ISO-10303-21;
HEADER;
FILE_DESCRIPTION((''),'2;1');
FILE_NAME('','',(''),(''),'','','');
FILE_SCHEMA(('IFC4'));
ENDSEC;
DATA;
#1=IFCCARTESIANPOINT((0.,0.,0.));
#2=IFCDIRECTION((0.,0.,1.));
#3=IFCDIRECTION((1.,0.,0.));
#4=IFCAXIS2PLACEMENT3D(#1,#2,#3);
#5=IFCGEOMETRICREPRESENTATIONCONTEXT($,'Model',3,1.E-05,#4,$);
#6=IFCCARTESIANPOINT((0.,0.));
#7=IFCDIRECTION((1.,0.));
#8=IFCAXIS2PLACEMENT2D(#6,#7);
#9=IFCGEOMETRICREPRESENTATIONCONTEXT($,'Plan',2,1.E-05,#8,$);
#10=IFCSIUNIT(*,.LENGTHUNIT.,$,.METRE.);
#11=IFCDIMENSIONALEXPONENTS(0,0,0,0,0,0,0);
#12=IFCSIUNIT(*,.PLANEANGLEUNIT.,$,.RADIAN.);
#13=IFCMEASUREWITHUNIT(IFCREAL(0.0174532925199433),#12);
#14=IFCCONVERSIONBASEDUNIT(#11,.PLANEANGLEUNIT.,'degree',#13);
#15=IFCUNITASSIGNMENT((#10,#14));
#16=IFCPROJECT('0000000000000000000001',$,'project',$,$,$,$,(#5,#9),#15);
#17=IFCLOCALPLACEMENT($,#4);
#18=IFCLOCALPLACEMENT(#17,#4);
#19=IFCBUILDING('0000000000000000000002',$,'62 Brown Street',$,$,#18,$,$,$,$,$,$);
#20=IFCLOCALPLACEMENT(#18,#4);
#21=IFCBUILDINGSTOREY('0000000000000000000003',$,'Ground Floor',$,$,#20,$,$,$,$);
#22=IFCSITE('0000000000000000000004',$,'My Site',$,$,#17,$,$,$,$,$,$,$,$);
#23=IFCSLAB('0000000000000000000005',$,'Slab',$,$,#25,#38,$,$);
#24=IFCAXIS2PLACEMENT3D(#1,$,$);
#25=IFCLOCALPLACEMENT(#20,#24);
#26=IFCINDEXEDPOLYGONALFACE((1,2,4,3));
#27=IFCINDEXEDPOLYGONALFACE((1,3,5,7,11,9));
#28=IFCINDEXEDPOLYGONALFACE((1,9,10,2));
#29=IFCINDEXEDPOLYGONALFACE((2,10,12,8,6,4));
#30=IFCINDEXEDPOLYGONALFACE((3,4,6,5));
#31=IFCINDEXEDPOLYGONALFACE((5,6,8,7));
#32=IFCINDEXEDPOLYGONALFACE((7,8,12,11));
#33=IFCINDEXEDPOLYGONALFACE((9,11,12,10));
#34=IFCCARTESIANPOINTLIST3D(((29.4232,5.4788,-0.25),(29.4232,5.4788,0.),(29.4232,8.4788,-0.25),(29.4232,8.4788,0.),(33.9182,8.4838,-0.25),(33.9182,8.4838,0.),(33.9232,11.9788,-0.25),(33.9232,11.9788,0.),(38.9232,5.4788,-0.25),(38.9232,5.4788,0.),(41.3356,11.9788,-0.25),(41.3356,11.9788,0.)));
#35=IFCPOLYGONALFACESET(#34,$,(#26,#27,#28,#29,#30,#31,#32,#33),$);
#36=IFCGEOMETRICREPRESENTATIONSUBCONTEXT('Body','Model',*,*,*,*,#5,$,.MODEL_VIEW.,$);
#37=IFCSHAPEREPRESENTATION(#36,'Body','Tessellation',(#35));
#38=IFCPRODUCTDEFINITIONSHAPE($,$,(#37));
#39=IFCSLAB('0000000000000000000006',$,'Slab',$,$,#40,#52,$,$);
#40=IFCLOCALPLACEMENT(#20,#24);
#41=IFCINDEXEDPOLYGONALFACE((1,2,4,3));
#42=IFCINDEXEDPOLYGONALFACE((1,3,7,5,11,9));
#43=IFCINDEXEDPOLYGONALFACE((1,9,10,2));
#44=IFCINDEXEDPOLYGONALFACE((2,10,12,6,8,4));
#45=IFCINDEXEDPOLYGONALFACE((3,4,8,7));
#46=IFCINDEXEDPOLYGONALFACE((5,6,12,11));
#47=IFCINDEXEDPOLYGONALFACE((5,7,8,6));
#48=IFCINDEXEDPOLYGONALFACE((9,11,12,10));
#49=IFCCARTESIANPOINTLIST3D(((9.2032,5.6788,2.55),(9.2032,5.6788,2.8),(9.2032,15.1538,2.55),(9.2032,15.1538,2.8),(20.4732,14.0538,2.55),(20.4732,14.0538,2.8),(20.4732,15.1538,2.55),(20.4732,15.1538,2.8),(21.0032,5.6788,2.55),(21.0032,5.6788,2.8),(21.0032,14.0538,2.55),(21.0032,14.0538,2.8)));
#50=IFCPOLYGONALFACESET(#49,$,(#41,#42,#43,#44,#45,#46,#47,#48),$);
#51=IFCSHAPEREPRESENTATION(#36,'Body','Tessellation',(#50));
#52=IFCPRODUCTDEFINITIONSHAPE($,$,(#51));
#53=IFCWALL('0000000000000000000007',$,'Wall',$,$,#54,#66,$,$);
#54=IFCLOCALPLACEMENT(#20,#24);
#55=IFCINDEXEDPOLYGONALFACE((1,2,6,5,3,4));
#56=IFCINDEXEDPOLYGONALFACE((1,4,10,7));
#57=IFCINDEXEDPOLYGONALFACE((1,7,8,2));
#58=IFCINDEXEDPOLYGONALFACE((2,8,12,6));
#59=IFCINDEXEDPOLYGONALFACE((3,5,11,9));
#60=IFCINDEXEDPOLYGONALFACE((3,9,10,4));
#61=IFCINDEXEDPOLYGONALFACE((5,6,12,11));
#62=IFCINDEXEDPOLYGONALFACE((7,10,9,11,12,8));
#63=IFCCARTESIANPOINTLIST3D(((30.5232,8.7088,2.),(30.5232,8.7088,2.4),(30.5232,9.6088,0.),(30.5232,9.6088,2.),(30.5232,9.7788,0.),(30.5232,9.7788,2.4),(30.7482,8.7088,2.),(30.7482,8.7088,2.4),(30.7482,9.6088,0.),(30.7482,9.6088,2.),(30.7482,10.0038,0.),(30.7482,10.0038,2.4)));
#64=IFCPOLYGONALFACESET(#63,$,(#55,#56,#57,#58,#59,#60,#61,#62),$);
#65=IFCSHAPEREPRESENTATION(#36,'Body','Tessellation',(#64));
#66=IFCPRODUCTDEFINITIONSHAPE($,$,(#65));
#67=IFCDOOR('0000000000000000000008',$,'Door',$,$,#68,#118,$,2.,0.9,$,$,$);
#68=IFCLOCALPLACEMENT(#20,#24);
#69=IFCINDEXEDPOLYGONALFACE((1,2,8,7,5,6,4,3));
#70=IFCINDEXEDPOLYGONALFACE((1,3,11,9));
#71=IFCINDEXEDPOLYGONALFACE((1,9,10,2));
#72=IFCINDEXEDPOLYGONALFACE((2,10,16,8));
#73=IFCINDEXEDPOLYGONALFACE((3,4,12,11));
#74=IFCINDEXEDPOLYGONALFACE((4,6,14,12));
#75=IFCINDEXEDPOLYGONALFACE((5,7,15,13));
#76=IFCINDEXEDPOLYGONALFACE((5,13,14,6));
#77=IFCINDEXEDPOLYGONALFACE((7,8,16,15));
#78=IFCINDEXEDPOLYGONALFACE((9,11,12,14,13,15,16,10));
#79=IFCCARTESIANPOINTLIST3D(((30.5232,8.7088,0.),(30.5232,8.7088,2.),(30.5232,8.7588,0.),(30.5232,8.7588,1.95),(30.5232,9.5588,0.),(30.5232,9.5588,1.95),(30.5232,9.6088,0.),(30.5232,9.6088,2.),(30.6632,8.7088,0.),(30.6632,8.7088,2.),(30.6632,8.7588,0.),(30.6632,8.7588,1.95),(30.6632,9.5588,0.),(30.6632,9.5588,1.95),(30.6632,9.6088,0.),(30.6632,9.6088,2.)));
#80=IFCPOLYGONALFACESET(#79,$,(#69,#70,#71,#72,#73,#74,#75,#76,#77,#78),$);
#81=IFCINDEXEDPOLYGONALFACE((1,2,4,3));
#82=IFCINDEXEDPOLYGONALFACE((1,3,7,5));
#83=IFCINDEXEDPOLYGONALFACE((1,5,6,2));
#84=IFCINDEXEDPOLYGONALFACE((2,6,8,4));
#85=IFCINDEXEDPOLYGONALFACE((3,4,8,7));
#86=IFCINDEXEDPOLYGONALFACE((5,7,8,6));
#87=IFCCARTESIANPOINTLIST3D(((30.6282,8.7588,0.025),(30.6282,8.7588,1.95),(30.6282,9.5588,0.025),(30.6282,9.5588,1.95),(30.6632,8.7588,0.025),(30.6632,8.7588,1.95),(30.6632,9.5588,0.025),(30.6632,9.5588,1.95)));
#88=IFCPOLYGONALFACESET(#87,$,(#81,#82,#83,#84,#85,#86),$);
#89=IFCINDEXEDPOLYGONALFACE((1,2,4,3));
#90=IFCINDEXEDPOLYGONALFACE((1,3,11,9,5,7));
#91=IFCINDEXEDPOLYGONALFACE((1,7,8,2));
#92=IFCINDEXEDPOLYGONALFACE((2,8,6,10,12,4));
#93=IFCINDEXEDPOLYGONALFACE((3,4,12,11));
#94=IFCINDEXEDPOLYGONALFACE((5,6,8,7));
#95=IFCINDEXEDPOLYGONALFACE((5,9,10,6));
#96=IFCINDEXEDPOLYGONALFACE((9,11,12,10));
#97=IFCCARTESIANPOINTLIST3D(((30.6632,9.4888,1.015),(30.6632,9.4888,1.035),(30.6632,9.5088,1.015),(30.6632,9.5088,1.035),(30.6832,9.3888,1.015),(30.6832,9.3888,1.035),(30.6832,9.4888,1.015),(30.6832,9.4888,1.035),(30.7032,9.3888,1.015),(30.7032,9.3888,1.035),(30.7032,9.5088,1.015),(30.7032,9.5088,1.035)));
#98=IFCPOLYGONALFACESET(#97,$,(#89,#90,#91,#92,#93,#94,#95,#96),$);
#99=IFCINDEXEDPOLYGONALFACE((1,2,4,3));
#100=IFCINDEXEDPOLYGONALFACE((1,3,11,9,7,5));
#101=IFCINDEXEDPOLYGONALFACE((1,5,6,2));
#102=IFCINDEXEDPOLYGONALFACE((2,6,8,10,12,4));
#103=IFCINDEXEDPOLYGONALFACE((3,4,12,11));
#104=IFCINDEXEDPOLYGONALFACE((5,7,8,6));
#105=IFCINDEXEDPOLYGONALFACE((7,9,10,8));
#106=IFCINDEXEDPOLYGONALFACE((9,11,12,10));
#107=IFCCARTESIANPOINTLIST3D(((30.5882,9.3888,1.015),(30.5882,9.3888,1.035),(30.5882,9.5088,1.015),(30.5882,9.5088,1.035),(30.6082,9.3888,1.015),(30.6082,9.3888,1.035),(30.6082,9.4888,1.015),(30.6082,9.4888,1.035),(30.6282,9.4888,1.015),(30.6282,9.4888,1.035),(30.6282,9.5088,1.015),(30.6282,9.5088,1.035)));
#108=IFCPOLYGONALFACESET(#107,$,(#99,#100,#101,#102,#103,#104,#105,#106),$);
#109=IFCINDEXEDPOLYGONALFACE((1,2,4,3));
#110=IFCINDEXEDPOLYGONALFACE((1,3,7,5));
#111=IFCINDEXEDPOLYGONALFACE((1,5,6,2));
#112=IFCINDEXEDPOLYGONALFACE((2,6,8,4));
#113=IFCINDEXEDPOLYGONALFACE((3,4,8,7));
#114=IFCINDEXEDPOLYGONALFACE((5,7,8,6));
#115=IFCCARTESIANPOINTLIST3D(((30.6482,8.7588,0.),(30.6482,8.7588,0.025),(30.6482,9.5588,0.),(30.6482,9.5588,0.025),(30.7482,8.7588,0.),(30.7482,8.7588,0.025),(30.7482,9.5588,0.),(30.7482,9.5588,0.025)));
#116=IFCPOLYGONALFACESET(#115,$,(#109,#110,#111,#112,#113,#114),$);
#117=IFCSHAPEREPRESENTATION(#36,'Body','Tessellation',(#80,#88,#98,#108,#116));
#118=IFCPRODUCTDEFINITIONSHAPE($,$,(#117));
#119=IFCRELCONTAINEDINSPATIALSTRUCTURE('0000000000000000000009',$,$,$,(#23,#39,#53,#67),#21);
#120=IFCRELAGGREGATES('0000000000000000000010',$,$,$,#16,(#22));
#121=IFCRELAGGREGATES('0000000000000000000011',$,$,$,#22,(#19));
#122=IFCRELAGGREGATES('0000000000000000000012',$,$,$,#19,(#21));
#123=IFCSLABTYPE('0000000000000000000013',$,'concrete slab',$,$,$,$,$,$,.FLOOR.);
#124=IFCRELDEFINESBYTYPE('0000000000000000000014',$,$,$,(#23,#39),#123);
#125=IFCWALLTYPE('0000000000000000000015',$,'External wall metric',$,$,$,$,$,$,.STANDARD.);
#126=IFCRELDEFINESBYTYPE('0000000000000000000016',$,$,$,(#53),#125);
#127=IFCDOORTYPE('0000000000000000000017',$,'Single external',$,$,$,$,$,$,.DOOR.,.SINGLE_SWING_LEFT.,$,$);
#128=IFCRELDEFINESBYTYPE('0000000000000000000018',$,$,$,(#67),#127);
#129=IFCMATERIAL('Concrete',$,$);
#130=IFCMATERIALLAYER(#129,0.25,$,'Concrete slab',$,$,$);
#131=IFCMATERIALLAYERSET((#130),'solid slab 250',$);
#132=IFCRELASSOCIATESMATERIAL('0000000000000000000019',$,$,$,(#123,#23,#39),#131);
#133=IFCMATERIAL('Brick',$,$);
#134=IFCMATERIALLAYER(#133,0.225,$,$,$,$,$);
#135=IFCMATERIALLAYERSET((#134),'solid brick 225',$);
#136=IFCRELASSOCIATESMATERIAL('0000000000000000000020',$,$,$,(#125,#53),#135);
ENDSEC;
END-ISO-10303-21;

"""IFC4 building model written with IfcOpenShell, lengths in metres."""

from ifc_helpers import new_model, entity, si_unit, converted_unit, frame, origin_with_axes, origin_2d_with_axis, place, context, subcontext, project, spatial, line, indexed_curve, outline, extrude, clip, halfspace, shape, source, transform, mapped, material, layer, layer_set, layer_usage, type_object, type_shapes, element, fill, save


model = new_model("IFC4")

# Units and contexts
model_context = context("Model", 3, precision=1e-05, world=origin_with_axes())
plan_context = context("Plan", 2, precision=1e-05, world=origin_2d_with_axis())
body_context_1 = subcontext(model_context, "Body", "Model", "MODEL_VIEW")
body_context_2 = subcontext(plan_context, "Body", "Plan", "PLAN_VIEW")
ifc_project = project(units=[si_unit("LENGTHUNIT", "METRE"), converted_unit("PLANEANGLEUNIT", "degree", entity("IfcReal", 0.0174532925199433), si_unit("PLANEANGLEUNIT", "RADIAN"), dimensions=[0, 0, 0, 0, 0, 0, 0])], contexts=[model_context, plan_context])

# Site, building, storey
site_placement = place(None, origin_with_axes())
site = spatial("IfcSite", under=ifc_project, at=site_placement, Name="My Site")
building_placement = place(site_placement, origin_with_axes())
building = spatial("IfcBuilding", under=site, at=building_placement, Name="62 Brown Street")
storey_placement = place(building_placement, origin_with_axes())
storey = spatial("IfcBuildingStorey", under=building, at=storey_placement, Name="Ground Floor")

# Slabs
ifc_material_1 = material(Name="Concrete")
ifc_layer_1 = layer(ifc_material_1, 0.25, Name="Concrete slab")
ifc_layer_set_1 = layer_set([ifc_layer_1], Name="solid slab 250")
ifc_layer_usage_1 = layer_usage(ifc_layer_set_1, "AXIS3", "POSITIVE", 0.0)
slab_type = type_object("IfcSlabType", Name="concrete slab", PredefinedType="FLOOR", material=ifc_layer_set_1)
slab_1_placement = place(storey_placement, frame((29.4232, 5.4788, -0.25), z_axis=(0.0, 0.0, 1.0), x_axis=(1.0, 0.0, 0.0)))
element("IfcSlab", 1, at=slab_1_placement, inside=storey, type_object=slab_type, material=ifc_layer_usage_1, Name="Slab", context=body_context_1, shape_type="SweptSolid", body=[
    extrude(outline(indexed_curve([(0.0, 0.0), (9.5, 0.0), (11.9124, 6.5), (0.0, 3.0), (4.5, 6.5), (4.495, 3.005)], segments=[line(1, 2), line(2, 3), line(3, 5), line(5, 6), line(6, 4), line(4, 1)], self_intersect=False)), None, (0.0, 0.0, 1.0), 0.25),
])
ifc_layer_usage_2 = layer_usage(ifc_layer_set_1, "AXIS3", "POSITIVE", 0.0)
slab_2_placement = place(storey_placement, frame((9.2032, 5.6788, 2.55), z_axis=(0.0, 0.0, 1.0), x_axis=(1.0, 0.0, 0.0)))
element("IfcSlab", 2, at=slab_2_placement, inside=storey, type_object=slab_type, material=ifc_layer_usage_2, Name="Slab", context=body_context_1, shape_type="SweptSolid", body=[
    extrude(outline(indexed_curve([(11.27, 9.475), (11.8, 0.0), (0.0, 0.0), (0.0, 9.475), (11.8, 8.375), (11.27, 8.375)], segments=[line(6, 1), line(1, 4), line(4, 3), line(3, 2), line(2, 5), line(5, 6)], self_intersect=False)), None, (0.0, 0.0, 1.0), 0.25),
])

# Shared definitions
ifc_material_2 = material(Name="Brick")
ifc_layer_2 = layer(ifc_material_2, 0.225)
ifc_layer_set_2 = layer_set([ifc_layer_2], Name="solid brick 225")
wall_type_1 = type_object("IfcWallType", Name="External wall metric", PredefinedType="STANDARD", material=ifc_layer_set_2)

# Wall, opening, door
ifc_layer_usage_3 = layer_usage(ifc_layer_set_2, "AXIS2", "POSITIVE", 0.0)
wall_1_placement = place(storey_placement, frame((30.7482, 8.7088, 0.0), z_axis=(0.0, 0.0, 1.0), x_axis=(0.0, 1.0, 0.0)))
wall_1 = element("IfcWall", 3, at=wall_1_placement, inside=storey, type_object=wall_type_1, material=ifc_layer_usage_3, Name="Wall", context=body_context_1, shape_type="Clipping", body=[
    clip(extrude(outline(indexed_curve([(0.0, 0.0), (0.0, 0.225), (1.295, 0.225), (1.295, 0.0), (0.0, 0.0)], self_intersect=False)), origin_with_axes(), (0.0, 0.0, 1.0), 2.4), halfspace(frame((1.295, 0.0, 0.0), z_axis=(0.675001, 0.675001, 0.0), x_axis=(-0.225, 0.225, 0.0)), False)),
])
shared_shape_1 = source(origin_with_axes(), body_context_1, "Body", "SweptSolid", [
    extrude(outline(indexed_curve([(0.0, 0.0), (0.9, 0.0), (0.9, 2.0), (0.0, 2.0)], segments=[line(1, 2, 3, 4, 1)])), frame((0.0, -0.6, 0.0), z_axis=(0.0, -1.0, 0.0), x_axis=(1.0, 0.0, 0.0)), (0.0, 0.0, -1.0), 1.2),
])
opening_1_placement = place(wall_1_placement, frame((0.0, 0.0, 0.0), z_axis=(0.0, 0.0, 1.0), x_axis=(1.0, 0.0, 0.0)))
opening_1 = element("IfcOpeningElement", 4, at=opening_1_placement, cuts=wall_1, PredefinedType="OPENING", context=body_context_1, shape_type="MappedRepresentation", body=[
    mapped(shared_shape_1, transform((0.0, 0.0, 0.0), x_axis=(1.0, 0.0, 0.0), y_axis=(0.0, 1.0, 0.0), z_axis=(0.0, 0.0, 1.0), scale=1.0)),
])
door_type_1 = type_object("IfcDoorType", Name="Single external", OperationType="SINGLE_SWING_LEFT", PredefinedType="DOOR")
shared_shape_2 = source(origin_with_axes(), body_context_1, "Body", "SweptSolid", [
    extrude(outline(indexed_curve([(0.0, 0.0), (0.0, 2.0), (0.9, 2.0), (0.9, 0.0), (0.85, 0.0), (0.85, 1.95), (0.05, 1.95), (0.05, 0.0)], segments=[line(1, 2, 3, 4, 5, 6, 7, 8, 1)])), frame((0.0, 0.085, 0.0), z_axis=(0.0, -1.0, 0.0), x_axis=(1.0, 0.0, 0.0)), (0.0, 0.0, -1.0), 0.14),
    extrude(outline(indexed_curve([(0.0, 0.0), (0.8, 0.0), (0.8, 0.035), (0.0, 0.035)], segments=[line(1, 2, 3, 4, 1)])), frame((0.05, 0.085, 0.025), z_axis=(0.0, 0.0, 1.0), x_axis=(1.0, 0.0, 0.0)), (0.0, 0.0, 1.0), 1.925),
    extrude(outline(indexed_curve([(0.0, 0.0), (0.0, -0.04), (-0.12, -0.04), (-0.12, -0.02), (-0.02, -0.02), (-0.02, 0.0)], segments=[line(1, 2, 3, 4, 5, 6, 1)])), frame((0.8, 0.085, 1.015), z_axis=(0.0, 0.0, 1.0), x_axis=(1.0, 0.0, 0.0)), (0.0, 0.0, 1.0), 0.02),
    extrude(outline(indexed_curve([(0.0, 0.0), (0.0, 0.04), (-0.12, 0.04), (-0.12, 0.02), (-0.02, 0.02), (-0.02, 0.0)], segments=[line(1, 2, 3, 4, 5, 6, 1)])), frame((0.8, 0.12, 1.015), z_axis=(0.0, 0.0, 1.0), x_axis=(1.0, 0.0, 0.0)), (0.0, 0.0, 1.0), 0.02),
    extrude(outline(indexed_curve([(0.0, 0.0), (0.8, 0.0), (0.8, 0.1), (0.0, 0.1)], segments=[line(1, 2, 3, 4, 1)])), frame((0.05, 0.0, 0.0), z_axis=(0.0, 0.0, 1.0), x_axis=(1.0, 0.0, 0.0)), (0.0, 0.0, 1.0), 0.025),
])
shared_shape_3 = source(origin_with_axes(), body_context_2, "Body", "Curve2D", [
    entity("IfcIndexedPolyCurve", entity("IfcCartesianPointList2D", [[0.0, 0.085], [0.05, 0.085], [0.05, 0.225], [0.0, 0.225]]), [entity("IfcLineIndex", [1, 2, 3, 4, 1])]),
    entity("IfcIndexedPolyCurve", entity("IfcCartesianPointList2D", [[0.9, 0.085], [0.85, 0.085], [0.85, 0.225], [0.9, 0.225]]), [entity("IfcLineIndex", [1, 2, 3, 4, 1])]),
    entity("IfcTrimmedCurve", entity("IfcEllipse", entity("IfcAxis2Placement2D", entity("IfcCartesianPoint", [0.085, 0.225]), entity("IfcDirection", [1.0, 0.0])), 0.765, 0.8), [entity("IfcCartesianPoint", [0.85, 0.225])], [entity("IfcCartesianPoint", [0.085, 1.025])], True, "CARTESIAN"),
    entity("IfcIndexedPolyCurve", entity("IfcCartesianPointList2D", [[0.05, 0.225], [0.085, 0.225], [0.085, 1.025], [0.05, 1.025]]), [entity("IfcLineIndex", [1, 2, 3, 4, 1])]),
])
type_shapes(door_type_1, [shared_shape_2, shared_shape_3])
door_1_placement = place(opening_1_placement, origin_with_axes())
door_1 = element("IfcDoor", 5, at=door_1_placement, inside=storey, type_object=door_type_1, Name="Door", OverallHeight=2.0, OverallWidth=0.9, shapes=[
    shape(body_context_1, "Body", "MappedRepresentation", [mapped(shared_shape_2, transform((0.0, 0.0, 0.0), x_axis=(1.0, 0.0, 0.0), y_axis=(0.0, 1.0, 0.0), z_axis=(0.0, 0.0, 1.0), scale=1.0))]),
    shape(body_context_2, "Body", "MappedRepresentation", [mapped(shared_shape_3, transform((0.0, 0.0, 0.0), x_axis=(1.0, 0.0, 0.0), y_axis=(0.0, 1.0, 0.0), z_axis=(0.0, 0.0, 1.0), scale=1.0))]),
])
fill(opening_1, door_1)

save(model, "model.ifc")
